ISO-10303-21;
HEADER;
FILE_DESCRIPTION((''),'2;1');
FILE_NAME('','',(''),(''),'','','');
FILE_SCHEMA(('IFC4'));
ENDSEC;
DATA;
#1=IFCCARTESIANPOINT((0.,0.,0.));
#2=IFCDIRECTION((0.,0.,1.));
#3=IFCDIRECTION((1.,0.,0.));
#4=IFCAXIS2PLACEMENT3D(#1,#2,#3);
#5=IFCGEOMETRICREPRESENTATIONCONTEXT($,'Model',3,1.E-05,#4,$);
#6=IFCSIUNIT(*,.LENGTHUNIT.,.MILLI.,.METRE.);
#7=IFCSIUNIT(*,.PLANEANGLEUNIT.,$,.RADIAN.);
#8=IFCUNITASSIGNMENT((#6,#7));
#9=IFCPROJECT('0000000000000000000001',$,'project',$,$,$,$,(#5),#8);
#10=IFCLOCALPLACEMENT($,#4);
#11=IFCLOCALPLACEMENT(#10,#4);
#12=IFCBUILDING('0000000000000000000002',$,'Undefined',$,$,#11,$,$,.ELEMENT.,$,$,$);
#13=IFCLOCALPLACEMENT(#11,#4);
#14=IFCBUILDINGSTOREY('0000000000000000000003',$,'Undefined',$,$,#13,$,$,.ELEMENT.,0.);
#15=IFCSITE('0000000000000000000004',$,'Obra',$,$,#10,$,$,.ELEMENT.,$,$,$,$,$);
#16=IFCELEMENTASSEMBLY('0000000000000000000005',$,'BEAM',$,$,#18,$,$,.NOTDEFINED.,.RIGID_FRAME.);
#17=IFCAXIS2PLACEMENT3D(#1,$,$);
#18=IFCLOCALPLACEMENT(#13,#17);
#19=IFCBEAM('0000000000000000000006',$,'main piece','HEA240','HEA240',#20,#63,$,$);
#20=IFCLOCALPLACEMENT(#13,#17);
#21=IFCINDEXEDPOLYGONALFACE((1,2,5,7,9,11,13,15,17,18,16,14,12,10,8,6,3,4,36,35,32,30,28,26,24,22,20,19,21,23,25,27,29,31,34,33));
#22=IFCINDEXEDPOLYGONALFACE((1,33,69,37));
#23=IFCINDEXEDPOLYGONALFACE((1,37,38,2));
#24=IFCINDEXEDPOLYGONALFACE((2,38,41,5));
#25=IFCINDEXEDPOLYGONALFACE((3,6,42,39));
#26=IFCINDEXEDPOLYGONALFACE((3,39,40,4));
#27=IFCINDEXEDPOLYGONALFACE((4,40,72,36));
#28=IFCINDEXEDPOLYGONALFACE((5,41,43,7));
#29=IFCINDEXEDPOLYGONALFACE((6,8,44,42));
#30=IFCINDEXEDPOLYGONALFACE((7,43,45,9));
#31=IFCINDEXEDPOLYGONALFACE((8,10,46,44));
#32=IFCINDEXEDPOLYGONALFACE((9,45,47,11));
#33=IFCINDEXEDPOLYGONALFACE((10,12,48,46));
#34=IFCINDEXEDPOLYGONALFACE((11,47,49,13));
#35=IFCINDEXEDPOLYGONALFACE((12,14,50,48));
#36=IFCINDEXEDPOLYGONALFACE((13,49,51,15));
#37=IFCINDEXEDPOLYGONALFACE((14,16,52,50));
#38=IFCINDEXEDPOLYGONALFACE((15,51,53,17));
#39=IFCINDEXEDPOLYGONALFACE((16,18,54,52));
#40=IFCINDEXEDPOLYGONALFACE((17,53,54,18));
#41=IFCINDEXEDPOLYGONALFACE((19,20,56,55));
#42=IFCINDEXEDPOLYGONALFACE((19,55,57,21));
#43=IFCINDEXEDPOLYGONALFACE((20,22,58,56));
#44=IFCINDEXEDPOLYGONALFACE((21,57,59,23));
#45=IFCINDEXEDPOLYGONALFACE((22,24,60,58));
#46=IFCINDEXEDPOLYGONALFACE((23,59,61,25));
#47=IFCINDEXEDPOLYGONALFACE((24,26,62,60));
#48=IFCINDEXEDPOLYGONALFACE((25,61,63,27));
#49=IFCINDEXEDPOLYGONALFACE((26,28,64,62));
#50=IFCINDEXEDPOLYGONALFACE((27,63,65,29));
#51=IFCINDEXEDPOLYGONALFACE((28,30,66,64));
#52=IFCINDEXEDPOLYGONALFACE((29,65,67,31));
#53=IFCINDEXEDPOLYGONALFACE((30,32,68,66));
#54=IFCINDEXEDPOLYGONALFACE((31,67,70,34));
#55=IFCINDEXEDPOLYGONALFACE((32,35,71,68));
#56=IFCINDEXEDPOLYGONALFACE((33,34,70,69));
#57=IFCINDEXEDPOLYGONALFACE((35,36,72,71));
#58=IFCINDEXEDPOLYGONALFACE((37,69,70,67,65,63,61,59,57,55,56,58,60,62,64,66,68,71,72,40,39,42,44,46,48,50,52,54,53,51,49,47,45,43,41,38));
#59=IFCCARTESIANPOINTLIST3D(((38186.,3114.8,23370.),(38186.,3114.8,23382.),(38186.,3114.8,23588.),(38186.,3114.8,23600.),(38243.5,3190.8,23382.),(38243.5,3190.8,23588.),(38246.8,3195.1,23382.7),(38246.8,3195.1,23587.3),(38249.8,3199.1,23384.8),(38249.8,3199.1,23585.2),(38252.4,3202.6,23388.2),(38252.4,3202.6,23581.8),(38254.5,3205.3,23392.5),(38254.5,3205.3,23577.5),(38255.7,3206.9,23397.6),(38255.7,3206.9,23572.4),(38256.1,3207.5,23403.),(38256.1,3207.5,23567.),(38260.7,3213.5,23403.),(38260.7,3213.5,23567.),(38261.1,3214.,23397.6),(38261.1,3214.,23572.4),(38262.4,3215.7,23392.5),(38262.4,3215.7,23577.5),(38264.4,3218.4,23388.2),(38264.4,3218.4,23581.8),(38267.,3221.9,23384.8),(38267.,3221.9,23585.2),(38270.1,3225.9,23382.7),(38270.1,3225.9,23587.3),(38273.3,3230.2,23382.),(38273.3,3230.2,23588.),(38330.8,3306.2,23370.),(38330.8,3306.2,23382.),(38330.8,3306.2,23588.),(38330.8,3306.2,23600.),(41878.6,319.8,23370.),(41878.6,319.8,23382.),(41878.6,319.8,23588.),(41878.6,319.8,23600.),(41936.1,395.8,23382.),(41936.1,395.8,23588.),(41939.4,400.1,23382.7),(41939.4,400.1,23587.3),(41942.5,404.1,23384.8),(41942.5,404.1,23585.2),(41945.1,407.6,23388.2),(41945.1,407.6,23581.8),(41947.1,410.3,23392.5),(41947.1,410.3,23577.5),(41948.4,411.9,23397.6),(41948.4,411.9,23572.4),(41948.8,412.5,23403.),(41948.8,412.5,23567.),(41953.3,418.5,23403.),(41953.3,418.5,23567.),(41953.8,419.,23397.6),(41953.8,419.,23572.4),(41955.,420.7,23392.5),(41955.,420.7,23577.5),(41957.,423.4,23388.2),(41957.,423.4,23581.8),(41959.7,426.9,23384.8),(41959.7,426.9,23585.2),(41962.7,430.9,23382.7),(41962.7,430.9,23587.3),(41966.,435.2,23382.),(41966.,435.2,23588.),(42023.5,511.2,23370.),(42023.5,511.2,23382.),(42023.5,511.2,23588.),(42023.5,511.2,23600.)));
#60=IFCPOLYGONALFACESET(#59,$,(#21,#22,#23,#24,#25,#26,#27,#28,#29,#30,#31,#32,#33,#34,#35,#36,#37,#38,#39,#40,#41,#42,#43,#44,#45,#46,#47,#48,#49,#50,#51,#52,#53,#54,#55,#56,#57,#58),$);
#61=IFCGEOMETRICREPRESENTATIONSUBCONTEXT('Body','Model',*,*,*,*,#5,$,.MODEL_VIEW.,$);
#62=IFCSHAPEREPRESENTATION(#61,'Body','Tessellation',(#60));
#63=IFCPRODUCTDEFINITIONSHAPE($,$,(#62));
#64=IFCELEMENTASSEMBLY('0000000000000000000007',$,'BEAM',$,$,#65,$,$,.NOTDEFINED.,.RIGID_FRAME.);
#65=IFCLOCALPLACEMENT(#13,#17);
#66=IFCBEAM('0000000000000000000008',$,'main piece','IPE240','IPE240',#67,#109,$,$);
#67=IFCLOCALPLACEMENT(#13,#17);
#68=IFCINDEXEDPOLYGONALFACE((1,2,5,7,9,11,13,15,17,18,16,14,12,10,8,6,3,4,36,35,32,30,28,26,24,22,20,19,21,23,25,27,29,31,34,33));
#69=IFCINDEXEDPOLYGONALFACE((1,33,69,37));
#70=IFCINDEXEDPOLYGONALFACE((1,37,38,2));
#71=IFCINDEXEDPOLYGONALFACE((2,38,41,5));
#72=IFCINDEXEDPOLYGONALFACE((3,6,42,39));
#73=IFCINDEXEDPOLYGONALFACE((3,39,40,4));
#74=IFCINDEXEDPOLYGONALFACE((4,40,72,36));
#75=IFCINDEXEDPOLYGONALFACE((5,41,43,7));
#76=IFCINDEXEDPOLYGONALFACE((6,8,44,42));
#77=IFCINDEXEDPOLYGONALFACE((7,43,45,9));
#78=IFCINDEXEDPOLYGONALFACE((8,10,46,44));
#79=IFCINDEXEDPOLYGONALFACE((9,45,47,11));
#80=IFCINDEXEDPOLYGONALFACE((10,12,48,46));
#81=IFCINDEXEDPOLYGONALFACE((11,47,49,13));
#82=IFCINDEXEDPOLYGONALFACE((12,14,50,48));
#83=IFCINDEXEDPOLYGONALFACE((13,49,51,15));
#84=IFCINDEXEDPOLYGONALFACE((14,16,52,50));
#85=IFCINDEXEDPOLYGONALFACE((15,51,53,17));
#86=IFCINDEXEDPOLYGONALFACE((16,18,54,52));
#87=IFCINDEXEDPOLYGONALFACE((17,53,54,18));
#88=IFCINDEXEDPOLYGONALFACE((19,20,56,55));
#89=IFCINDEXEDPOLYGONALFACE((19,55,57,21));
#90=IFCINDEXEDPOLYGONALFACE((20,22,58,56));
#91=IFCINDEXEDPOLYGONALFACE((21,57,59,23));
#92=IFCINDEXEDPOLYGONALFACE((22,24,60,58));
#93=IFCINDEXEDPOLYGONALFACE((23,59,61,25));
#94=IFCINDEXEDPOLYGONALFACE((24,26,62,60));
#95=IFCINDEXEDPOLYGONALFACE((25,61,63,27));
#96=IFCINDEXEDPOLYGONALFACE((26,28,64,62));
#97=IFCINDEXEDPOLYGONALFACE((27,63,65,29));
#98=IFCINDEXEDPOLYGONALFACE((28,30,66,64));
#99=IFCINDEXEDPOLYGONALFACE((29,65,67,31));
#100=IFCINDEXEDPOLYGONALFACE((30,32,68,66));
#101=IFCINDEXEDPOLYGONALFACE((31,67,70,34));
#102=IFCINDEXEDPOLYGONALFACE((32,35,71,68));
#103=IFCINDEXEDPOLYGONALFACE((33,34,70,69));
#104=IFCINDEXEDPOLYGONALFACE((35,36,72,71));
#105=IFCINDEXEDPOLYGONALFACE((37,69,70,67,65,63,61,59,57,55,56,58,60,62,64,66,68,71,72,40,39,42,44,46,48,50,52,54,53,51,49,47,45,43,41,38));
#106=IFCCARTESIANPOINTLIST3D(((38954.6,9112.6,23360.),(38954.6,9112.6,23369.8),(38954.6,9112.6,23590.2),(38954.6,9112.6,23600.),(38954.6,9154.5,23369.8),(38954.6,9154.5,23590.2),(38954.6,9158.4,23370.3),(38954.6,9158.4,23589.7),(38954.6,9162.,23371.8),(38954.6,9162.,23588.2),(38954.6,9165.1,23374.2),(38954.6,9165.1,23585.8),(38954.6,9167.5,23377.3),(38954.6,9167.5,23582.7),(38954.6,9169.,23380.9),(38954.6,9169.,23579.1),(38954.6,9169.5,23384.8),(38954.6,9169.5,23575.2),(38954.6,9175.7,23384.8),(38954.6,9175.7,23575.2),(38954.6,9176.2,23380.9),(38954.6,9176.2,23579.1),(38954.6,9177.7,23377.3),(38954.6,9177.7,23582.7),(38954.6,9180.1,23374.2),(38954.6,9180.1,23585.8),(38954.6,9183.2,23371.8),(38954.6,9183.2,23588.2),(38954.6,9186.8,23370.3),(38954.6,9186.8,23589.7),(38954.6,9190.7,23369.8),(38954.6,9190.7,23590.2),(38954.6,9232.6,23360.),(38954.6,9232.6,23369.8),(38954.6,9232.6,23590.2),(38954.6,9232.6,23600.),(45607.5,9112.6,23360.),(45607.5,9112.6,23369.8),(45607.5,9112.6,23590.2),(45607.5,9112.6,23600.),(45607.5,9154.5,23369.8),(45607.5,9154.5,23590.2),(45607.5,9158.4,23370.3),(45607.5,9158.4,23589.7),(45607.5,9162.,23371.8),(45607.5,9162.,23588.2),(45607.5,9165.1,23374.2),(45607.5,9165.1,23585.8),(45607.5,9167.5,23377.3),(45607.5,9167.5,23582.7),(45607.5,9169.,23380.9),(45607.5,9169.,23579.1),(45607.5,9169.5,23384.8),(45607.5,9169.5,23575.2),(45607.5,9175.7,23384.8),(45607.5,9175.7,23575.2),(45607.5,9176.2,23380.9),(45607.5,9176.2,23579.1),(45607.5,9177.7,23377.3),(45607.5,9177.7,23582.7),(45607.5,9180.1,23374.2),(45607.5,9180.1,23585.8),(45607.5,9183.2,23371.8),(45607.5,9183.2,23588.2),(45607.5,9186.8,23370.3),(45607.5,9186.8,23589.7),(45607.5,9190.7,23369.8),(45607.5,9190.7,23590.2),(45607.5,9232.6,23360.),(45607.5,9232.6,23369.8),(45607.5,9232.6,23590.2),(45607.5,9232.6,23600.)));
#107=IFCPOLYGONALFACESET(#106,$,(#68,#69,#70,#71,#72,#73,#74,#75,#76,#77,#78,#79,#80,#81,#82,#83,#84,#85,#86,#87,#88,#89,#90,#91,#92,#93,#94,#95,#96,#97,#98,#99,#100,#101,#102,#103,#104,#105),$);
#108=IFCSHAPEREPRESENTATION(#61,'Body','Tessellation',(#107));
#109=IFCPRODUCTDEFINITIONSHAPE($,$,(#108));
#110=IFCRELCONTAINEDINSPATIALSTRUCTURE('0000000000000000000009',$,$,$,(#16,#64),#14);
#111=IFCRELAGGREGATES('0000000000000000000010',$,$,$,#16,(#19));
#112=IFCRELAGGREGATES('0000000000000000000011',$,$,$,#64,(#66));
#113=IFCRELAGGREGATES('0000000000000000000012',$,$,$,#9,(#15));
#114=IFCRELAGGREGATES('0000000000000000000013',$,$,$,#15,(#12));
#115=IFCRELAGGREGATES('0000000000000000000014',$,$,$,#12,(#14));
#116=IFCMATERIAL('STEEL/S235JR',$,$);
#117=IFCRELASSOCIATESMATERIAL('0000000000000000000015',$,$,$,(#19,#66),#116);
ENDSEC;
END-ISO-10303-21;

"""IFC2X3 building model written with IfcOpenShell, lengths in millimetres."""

from ifc_helpers import new_model, si_unit, frame, origin_with_axes, origin_2d_with_axis, place, context, subcontext, project, spatial, i_section, extrude, material, element, aggregate, save


model = new_model("IFC2X3")

# Units and contexts
model_context = context("Model", 3, precision=1e-05, world=origin_with_axes())
body_context = subcontext(model_context, "Body", "Model", "MODEL_VIEW")
ifc_project = project(units=[si_unit("LENGTHUNIT", "METRE", prefix="MILLI"), si_unit("PLANEANGLEUNIT", "RADIAN")], contexts=[model_context])

# Site, building, storey
site_placement = place(None, origin_with_axes())
site = spatial("IfcSite", under=ifc_project, at=site_placement, Name="Obra", CompositionType="ELEMENT")
building_placement = place(site_placement, origin_with_axes())
building = spatial("IfcBuilding", under=site, at=building_placement, Name="Undefined", CompositionType="ELEMENT")
storey_placement = place(building_placement, origin_with_axes())
storey = spatial("IfcBuildingStorey", under=building, at=storey_placement, Name="Undefined", CompositionType="ELEMENT", Elevation=0.0)

# Element assemblies, beams
assembly_1_placement = place(storey_placement, origin_with_axes())
assembly_1 = element("IfcElementAssembly", 1, at=assembly_1_placement, inside=storey, Name="BEAM", AssemblyPlace="NOTDEFINED", PredefinedType="RIGID_FRAME")
ifc_material_1 = material(Name="STEEL/S235JR")
beam_1_placement = place(assembly_1_placement, frame((38258.4, 3210.5, 23485.0), z_axis=(0.0, 0.0, 1.0), x_axis=(0.797349, -0.603519, 0.0)))
beam_1 = element("IfcBeam", 2, at=beam_1_placement, material=ifc_material_1, Name="main piece", Description="HEA240", ObjectType="HEA240", context=body_context, shape_type="SweptSolid", body=[
    extrude(i_section(OverallWidth=240.0, OverallDepth=230.0, WebThickness=7.5, FlangeThickness=12.0, FilletRadius=21.0, at=origin_2d_with_axis()), frame((4631.2, 0.0, 0.0), z_axis=(-1.0, 0.0, 0.0), x_axis=(0.0, -1.0, 0.0)), (0.0, 0.0, 1.0), 4631.2),
])
aggregate(assembly_1, [beam_1])
assembly_2_placement = place(storey_placement, origin_with_axes())
assembly_2 = element("IfcElementAssembly", 3, at=assembly_2_placement, inside=storey, Name="BEAM", AssemblyPlace="NOTDEFINED", PredefinedType="RIGID_FRAME")
beam_2_placement = place(assembly_2_placement, frame((38954.6, 9172.6, 23480.0), z_axis=(0.0, 0.0, 1.0), x_axis=(1.0, 0.0, 0.0)))
beam_2 = element("IfcBeam", 4, at=beam_2_placement, material=ifc_material_1, Name="main piece", Description="IPE240", ObjectType="IPE240", context=body_context, shape_type="SweptSolid", body=[
    extrude(i_section(OverallWidth=120.0, OverallDepth=240.0, WebThickness=6.2, FlangeThickness=9.8, FilletRadius=15.0, at=origin_2d_with_axis()), frame((6652.9, 0.0, 0.0), z_axis=(-1.0, 0.0, 0.0), x_axis=(0.0, -1.0, 0.0)), (0.0, 0.0, 1.0), 6652.9),
])
aggregate(assembly_2, [beam_2])

save(model, "model.ifc")
